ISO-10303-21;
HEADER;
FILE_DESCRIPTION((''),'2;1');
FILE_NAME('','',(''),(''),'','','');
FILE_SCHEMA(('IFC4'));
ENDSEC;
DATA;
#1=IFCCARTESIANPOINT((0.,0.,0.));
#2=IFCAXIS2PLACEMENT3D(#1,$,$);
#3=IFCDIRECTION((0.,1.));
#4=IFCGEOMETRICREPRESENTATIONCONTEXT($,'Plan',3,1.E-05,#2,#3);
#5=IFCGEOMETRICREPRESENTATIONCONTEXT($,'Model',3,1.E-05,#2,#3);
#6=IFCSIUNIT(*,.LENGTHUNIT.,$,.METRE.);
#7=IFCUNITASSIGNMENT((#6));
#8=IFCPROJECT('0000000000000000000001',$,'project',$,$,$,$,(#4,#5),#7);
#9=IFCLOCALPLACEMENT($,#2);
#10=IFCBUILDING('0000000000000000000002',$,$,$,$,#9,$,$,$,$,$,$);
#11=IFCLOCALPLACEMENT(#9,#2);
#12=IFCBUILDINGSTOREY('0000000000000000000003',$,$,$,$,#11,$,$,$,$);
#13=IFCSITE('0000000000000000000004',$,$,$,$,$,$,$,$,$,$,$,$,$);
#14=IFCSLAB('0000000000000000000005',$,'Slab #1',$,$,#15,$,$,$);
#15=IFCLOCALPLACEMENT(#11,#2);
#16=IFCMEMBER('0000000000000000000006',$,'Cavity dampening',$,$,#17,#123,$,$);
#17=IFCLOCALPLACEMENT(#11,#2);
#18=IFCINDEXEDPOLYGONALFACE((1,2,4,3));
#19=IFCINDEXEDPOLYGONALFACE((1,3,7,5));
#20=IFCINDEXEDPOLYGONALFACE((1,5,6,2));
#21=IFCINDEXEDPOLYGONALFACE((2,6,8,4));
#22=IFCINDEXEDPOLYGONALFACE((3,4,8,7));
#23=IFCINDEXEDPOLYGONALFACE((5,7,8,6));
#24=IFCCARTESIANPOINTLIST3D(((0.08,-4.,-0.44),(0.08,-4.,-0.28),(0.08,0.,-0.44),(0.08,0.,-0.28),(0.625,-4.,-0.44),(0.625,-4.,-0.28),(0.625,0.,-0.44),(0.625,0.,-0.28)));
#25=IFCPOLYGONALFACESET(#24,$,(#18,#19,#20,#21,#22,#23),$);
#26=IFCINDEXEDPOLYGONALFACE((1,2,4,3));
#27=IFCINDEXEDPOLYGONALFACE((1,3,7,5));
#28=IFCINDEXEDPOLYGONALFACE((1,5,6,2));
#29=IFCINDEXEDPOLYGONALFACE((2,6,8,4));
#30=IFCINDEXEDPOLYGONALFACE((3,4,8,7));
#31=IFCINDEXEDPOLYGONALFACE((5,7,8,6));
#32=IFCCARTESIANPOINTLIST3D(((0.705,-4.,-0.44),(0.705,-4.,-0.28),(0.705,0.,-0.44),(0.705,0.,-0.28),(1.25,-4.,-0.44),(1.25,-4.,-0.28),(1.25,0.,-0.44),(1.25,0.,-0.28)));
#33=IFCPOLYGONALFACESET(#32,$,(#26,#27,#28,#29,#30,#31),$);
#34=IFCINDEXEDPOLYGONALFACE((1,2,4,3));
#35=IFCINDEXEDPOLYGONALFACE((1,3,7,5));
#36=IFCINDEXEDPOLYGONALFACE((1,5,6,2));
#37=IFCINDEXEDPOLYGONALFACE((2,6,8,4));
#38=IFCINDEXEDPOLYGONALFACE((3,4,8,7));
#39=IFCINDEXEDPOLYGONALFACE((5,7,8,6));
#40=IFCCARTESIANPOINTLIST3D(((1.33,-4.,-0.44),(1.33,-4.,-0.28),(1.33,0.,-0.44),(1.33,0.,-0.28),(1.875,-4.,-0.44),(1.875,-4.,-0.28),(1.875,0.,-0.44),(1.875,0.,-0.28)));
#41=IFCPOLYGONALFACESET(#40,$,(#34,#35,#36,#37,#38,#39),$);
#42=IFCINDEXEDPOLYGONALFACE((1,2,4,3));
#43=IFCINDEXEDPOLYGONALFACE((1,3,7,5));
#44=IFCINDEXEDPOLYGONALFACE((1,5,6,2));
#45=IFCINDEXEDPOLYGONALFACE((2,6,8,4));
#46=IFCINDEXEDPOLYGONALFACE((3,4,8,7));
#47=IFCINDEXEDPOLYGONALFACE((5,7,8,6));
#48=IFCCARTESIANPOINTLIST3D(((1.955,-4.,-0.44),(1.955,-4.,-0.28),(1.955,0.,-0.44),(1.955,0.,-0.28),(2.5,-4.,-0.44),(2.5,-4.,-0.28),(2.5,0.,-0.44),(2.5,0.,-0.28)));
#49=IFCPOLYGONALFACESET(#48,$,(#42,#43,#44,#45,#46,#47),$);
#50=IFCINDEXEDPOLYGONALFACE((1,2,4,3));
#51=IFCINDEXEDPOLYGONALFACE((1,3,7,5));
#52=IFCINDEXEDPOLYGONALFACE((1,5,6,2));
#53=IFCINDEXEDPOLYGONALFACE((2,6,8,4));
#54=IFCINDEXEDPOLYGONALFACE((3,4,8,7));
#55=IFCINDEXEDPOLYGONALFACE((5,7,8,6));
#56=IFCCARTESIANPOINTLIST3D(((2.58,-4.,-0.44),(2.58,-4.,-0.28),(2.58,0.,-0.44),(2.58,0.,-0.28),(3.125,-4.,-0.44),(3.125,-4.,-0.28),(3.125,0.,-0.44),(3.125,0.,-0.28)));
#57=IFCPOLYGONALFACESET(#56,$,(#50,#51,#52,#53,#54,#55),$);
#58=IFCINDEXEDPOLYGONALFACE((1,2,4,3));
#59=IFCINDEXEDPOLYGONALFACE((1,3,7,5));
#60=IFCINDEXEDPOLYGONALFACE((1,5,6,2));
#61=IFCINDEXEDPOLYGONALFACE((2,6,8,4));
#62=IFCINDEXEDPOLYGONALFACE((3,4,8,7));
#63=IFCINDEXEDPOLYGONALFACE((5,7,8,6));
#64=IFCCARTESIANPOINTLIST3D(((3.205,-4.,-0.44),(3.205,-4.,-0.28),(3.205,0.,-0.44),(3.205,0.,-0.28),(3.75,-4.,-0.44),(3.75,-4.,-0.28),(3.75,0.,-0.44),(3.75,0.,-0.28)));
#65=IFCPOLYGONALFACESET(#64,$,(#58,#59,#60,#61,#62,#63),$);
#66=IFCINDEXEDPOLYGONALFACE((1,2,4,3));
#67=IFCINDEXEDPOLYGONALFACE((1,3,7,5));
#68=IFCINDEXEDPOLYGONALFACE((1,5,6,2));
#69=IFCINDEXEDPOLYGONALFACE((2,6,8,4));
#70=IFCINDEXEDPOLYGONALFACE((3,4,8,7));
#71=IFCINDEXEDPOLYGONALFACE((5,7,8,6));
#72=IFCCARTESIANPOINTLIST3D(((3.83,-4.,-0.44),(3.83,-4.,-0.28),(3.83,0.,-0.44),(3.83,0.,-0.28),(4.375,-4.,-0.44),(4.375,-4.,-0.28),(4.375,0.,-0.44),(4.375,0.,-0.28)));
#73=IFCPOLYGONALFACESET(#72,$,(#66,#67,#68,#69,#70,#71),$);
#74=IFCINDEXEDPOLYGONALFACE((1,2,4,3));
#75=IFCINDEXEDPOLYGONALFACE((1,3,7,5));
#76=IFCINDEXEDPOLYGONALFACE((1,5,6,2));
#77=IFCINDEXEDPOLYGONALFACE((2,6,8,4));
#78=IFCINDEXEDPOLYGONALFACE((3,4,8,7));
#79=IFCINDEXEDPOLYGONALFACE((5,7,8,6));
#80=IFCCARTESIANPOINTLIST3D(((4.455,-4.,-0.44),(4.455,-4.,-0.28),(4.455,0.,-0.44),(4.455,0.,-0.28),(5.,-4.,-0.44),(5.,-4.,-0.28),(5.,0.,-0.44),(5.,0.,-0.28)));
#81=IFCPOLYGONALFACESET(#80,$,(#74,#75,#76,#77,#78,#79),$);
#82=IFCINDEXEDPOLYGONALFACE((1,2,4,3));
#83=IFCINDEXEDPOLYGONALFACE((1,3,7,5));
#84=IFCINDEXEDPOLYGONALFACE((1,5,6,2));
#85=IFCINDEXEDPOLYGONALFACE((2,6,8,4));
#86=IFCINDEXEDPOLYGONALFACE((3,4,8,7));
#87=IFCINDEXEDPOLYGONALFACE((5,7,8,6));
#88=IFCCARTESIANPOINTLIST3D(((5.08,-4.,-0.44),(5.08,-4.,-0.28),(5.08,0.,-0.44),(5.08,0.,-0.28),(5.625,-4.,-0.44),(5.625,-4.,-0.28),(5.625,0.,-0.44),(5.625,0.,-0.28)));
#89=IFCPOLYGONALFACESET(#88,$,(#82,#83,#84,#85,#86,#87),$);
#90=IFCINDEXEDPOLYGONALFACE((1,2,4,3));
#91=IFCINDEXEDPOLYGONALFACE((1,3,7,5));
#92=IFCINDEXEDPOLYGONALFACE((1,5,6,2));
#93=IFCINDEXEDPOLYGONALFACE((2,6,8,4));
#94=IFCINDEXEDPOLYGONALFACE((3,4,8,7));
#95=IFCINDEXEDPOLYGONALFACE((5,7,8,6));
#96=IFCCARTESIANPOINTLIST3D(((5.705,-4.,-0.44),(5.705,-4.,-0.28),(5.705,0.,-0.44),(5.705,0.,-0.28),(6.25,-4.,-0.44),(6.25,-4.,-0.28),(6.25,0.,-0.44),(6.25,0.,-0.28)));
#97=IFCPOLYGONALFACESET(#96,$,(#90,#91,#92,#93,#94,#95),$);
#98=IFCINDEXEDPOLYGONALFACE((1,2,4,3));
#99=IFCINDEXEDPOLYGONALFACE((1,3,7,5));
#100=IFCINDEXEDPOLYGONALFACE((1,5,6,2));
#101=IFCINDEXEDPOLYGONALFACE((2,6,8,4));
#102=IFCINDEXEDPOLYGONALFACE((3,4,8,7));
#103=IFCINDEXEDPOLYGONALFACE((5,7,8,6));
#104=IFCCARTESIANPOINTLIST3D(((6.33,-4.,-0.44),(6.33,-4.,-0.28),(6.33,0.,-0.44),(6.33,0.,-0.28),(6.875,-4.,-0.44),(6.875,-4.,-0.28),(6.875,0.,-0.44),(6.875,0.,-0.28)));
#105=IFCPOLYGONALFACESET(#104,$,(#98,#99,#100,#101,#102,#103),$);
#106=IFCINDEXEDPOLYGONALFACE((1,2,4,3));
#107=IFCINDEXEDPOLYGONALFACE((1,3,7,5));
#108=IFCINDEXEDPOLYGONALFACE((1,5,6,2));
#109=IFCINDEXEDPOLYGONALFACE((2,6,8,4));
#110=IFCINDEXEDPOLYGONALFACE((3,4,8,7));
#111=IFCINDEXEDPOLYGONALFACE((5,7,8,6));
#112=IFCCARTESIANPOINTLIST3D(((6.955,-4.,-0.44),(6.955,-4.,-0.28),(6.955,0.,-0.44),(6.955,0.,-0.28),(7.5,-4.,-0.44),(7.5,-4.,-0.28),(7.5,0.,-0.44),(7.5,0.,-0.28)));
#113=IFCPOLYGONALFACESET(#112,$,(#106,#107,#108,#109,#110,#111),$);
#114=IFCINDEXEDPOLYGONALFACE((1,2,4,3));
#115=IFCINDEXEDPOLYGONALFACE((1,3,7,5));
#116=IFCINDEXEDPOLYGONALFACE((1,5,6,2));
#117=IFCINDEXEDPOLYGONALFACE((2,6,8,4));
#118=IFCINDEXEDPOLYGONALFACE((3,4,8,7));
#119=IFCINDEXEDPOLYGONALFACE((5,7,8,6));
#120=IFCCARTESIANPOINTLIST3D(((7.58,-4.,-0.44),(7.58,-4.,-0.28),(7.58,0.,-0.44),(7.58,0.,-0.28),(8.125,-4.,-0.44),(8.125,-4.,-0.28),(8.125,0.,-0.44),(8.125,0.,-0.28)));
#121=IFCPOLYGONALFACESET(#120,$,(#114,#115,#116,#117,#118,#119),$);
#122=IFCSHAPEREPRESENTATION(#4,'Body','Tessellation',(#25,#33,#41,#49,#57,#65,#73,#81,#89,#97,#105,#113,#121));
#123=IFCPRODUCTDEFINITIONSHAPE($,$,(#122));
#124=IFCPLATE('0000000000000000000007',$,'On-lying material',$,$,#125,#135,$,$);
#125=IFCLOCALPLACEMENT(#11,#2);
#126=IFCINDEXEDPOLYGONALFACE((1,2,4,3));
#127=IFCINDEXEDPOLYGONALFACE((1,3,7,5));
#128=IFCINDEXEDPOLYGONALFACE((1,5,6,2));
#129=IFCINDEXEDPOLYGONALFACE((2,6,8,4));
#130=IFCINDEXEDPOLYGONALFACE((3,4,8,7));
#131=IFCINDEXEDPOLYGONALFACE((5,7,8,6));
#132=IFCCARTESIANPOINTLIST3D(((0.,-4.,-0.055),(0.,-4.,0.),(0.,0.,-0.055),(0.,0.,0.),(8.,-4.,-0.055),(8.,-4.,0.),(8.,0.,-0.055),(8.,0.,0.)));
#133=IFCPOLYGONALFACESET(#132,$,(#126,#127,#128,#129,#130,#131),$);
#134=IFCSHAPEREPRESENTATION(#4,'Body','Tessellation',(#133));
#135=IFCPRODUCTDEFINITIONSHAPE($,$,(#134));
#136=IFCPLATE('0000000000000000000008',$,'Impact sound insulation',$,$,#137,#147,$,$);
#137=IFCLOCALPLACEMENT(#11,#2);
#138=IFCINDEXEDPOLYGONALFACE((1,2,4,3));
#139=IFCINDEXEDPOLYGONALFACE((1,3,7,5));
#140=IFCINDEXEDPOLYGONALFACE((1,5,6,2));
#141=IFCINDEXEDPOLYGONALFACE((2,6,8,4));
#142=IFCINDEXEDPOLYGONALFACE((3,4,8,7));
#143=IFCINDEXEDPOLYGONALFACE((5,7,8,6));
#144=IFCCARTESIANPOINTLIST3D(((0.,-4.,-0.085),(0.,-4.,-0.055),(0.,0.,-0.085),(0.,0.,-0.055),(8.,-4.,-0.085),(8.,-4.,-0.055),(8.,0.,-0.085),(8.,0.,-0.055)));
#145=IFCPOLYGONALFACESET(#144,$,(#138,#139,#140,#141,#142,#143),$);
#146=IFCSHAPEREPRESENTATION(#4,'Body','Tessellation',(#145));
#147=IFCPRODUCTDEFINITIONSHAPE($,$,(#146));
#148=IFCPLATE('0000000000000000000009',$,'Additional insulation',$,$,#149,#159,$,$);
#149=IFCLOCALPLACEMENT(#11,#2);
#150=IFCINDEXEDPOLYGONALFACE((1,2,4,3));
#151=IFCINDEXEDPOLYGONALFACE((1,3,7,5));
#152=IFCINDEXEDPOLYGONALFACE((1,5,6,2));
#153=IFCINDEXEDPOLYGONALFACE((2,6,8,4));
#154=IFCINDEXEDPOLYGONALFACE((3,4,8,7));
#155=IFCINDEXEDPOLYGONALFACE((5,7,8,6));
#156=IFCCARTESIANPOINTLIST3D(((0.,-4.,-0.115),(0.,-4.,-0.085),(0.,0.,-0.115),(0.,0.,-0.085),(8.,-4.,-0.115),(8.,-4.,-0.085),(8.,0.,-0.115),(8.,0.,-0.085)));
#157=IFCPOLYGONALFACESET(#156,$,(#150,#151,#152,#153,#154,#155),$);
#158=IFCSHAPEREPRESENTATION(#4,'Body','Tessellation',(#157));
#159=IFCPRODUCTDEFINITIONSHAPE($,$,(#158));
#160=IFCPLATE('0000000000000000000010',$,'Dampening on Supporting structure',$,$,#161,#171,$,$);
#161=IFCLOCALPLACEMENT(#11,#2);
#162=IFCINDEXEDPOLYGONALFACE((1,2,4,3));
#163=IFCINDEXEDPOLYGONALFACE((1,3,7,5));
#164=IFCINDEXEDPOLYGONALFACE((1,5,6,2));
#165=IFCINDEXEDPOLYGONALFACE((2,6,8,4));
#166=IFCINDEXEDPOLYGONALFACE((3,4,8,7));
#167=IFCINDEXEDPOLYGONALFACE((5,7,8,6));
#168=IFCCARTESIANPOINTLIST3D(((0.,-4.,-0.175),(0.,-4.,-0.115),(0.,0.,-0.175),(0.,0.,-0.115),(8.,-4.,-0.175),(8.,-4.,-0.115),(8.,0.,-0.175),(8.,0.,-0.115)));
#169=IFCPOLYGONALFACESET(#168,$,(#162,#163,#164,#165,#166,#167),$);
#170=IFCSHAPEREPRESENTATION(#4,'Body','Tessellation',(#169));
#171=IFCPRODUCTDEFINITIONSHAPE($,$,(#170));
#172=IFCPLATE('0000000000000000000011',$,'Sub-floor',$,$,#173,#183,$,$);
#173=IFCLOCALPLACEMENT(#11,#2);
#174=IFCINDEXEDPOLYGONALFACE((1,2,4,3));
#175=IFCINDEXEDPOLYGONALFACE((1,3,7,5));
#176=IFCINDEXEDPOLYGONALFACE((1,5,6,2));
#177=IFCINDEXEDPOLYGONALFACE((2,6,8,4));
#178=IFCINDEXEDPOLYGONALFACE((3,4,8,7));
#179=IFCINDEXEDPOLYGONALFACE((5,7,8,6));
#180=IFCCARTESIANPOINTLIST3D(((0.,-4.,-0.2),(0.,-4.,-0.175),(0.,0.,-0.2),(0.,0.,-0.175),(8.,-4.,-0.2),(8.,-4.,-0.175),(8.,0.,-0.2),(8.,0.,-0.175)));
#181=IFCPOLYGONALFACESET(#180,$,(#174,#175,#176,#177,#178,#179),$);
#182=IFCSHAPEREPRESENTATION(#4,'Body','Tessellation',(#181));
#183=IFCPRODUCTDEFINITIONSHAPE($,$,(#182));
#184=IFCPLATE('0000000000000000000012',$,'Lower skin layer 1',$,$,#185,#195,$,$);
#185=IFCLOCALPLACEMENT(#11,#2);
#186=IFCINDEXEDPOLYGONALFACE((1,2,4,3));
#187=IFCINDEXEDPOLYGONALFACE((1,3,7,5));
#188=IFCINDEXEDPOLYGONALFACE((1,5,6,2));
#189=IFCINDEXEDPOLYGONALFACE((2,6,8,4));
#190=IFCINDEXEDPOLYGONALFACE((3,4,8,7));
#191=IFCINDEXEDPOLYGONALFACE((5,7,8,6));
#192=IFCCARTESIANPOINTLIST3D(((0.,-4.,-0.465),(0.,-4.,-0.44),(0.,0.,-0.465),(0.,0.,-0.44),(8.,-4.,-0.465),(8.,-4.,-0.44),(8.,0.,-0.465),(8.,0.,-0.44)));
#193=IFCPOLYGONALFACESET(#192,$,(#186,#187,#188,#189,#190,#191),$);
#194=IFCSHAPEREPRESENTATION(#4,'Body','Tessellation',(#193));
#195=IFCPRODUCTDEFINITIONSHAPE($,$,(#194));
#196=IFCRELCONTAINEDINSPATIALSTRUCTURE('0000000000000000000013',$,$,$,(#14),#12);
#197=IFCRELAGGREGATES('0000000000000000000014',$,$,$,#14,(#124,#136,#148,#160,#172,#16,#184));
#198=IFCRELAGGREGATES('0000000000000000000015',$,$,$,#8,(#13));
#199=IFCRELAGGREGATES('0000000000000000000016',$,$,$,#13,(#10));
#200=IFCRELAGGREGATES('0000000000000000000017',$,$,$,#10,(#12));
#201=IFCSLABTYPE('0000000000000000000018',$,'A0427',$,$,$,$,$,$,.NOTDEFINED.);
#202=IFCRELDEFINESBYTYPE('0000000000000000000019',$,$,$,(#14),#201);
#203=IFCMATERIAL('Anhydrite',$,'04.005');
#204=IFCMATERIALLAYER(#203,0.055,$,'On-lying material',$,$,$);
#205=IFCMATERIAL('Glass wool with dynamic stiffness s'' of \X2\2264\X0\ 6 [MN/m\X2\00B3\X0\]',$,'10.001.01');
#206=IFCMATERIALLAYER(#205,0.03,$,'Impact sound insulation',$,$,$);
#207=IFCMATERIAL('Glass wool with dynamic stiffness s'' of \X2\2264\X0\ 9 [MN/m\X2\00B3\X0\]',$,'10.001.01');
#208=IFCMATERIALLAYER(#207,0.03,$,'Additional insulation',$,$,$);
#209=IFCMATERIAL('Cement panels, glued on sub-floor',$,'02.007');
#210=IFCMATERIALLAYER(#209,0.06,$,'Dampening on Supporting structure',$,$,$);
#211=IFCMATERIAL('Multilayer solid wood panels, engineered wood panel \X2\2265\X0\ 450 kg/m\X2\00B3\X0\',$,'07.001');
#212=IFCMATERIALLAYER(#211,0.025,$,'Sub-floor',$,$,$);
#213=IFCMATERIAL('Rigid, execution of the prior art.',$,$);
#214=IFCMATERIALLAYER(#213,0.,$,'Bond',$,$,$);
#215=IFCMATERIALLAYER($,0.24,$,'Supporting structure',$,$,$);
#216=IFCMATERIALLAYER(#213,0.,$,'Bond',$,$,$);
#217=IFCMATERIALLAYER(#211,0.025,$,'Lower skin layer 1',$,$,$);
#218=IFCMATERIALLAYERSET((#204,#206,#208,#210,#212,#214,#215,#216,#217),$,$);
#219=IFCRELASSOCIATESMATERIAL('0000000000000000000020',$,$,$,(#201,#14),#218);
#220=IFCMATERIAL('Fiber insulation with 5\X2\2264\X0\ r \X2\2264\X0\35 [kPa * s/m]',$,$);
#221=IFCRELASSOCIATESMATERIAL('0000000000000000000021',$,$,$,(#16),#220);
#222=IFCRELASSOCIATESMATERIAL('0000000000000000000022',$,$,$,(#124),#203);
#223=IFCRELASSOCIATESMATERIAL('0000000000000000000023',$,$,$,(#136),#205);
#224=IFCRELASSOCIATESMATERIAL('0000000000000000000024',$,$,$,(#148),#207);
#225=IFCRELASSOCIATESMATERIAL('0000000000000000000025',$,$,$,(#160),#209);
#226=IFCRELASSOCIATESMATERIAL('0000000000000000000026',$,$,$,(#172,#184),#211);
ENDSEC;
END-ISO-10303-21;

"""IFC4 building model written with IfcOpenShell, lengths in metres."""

from ifc_helpers import new_model, si_unit, direction, frame, frame_2d, origin, origin_with_axes, place, context, project, spatial, rectangle, extrude, material, layer, layer_set, type_object, element, aggregate, save


model = new_model("IFC4")

# Units and contexts
plan_context = context("Plan", 3, precision=1e-05, world=origin(), true_north=direction((0.0, 1.0)))
model_context = context("Model", 3, precision=1e-05, world=origin(), true_north=direction((0.0, 1.0)))
ifc_project = project(units=[si_unit("LENGTHUNIT", "METRE")], contexts=[plan_context, model_context])

# Site, building, storey
site = spatial("IfcSite", under=ifc_project)
building_placement = place(None, origin())
building = spatial("IfcBuilding", under=site, at=building_placement)
storey_placement = place(building_placement, origin())
storey = spatial("IfcBuildingStorey", under=building, at=storey_placement)

# Slab, member, plates
ifc_material_1 = material(Name="Anhydrite", Category="04.005")
ifc_layer_1 = layer(ifc_material_1, 0.055, Name="On-lying material")
ifc_material_2 = material(Name="Glass wool with dynamic stiffness s' of ≤ 6 [MN/m³]", Category="10.001.01")
ifc_layer_2 = layer(ifc_material_2, 0.03, Name="Impact sound insulation")
ifc_material_3 = material(Name="Glass wool with dynamic stiffness s' of ≤ 9 [MN/m³]", Category="10.001.01")
ifc_layer_3 = layer(ifc_material_3, 0.03, Name="Additional insulation")
ifc_material_4 = material(Name="Cement panels, glued on sub-floor", Category="02.007")
ifc_layer_4 = layer(ifc_material_4, 0.06, Name="Dampening on Supporting structure")
ifc_material_5 = material(Name="Multilayer solid wood panels, engineered wood panel ≥ 450 kg/m³", Category="07.001")
ifc_layer_5 = layer(ifc_material_5, 0.025, Name="Sub-floor")
ifc_material_6 = material(Name="Rigid, execution of the prior art.")
ifc_layer_6 = layer(ifc_material_6, 0.0, Name="Bond")
ifc_layer_7 = layer(None, 0.24, Name="Supporting structure")
ifc_layer_8 = layer(ifc_material_6, 0.0, Name="Bond")
ifc_layer_9 = layer(ifc_material_5, 0.025, Name="Lower skin layer 1")
ifc_layer_set = layer_set([ifc_layer_1, ifc_layer_2, ifc_layer_3, ifc_layer_4, ifc_layer_5, ifc_layer_6, ifc_layer_7, ifc_layer_8, ifc_layer_9])
slab_type = type_object("IfcSlabType", Name="A0427", PredefinedType="NOTDEFINED", material=ifc_layer_set)
slab_placement = place(None, frame((0.0, 0.0, 0.0), z_axis=(0.0, 0.0, -1.0), x_axis=(1.0, 0.0, 0.0)))
slab = element("IfcSlab", 1, at=slab_placement, inside=storey, type_object=slab_type, material=ifc_layer_set, Name="Slab #1")
ifc_material_7 = material(Name="Fiber insulation with 5≤ r ≤35 [kPa * s/m]")
member_1_placement = place(slab_placement, origin())
member_1 = element("IfcMember", 2, at=member_1_placement, material=ifc_material_7, Name="Cavity dampening", context=plan_context, shape_type="SweptSolid", body=[
    extrude(rectangle(XDim=0.545, YDim=0.16, at=frame_2d((0.2725, 0.08), x_axis=(1.0, 0.0))), frame((0.08, 4.0, 0.28), z_axis=(0.0, -1.0, 0.0), x_axis=(1.0, 0.0, 0.0)), (0.0, 0.0, 1.0), 4.0),
    extrude(rectangle(XDim=0.545, YDim=0.16, at=frame_2d((0.2725, 0.08), x_axis=(1.0, 0.0))), frame((0.705, 4.0, 0.28), z_axis=(0.0, -1.0, 0.0), x_axis=(1.0, 0.0, 0.0)), (0.0, 0.0, 1.0), 4.0),
    extrude(rectangle(XDim=0.545, YDim=0.16, at=frame_2d((0.2725, 0.08), x_axis=(1.0, 0.0))), frame((1.33, 4.0, 0.28), z_axis=(0.0, -1.0, 0.0), x_axis=(1.0, 0.0, 0.0)), (0.0, 0.0, 1.0), 4.0),
    extrude(rectangle(XDim=0.545, YDim=0.16, at=frame_2d((0.2725, 0.08), x_axis=(1.0, 0.0))), frame((1.955, 4.0, 0.28), z_axis=(0.0, -1.0, 0.0), x_axis=(1.0, 0.0, 0.0)), (0.0, 0.0, 1.0), 4.0),
    extrude(rectangle(XDim=0.545, YDim=0.16, at=frame_2d((0.2725, 0.08), x_axis=(1.0, 0.0))), frame((2.58, 4.0, 0.28), z_axis=(0.0, -1.0, 0.0), x_axis=(1.0, 0.0, 0.0)), (0.0, 0.0, 1.0), 4.0),
    extrude(rectangle(XDim=0.545, YDim=0.16, at=frame_2d((0.2725, 0.08), x_axis=(1.0, 0.0))), frame((3.205, 4.0, 0.28), z_axis=(0.0, -1.0, 0.0), x_axis=(1.0, 0.0, 0.0)), (0.0, 0.0, 1.0), 4.0),
    extrude(rectangle(XDim=0.545, YDim=0.16, at=frame_2d((0.2725, 0.08), x_axis=(1.0, 0.0))), frame((3.83, 4.0, 0.28), z_axis=(0.0, -1.0, 0.0), x_axis=(1.0, 0.0, 0.0)), (0.0, 0.0, 1.0), 4.0),
    extrude(rectangle(XDim=0.545, YDim=0.16, at=frame_2d((0.2725, 0.08), x_axis=(1.0, 0.0))), frame((4.455, 4.0, 0.28), z_axis=(0.0, -1.0, 0.0), x_axis=(1.0, 0.0, 0.0)), (0.0, 0.0, 1.0), 4.0),
    extrude(rectangle(XDim=0.545, YDim=0.16, at=frame_2d((0.2725, 0.08), x_axis=(1.0, 0.0))), frame((5.08, 4.0, 0.28), z_axis=(0.0, -1.0, 0.0), x_axis=(1.0, 0.0, 0.0)), (0.0, 0.0, 1.0), 4.0),
    extrude(rectangle(XDim=0.545, YDim=0.16, at=frame_2d((0.2725, 0.08), x_axis=(1.0, 0.0))), frame((5.705, 4.0, 0.28), z_axis=(0.0, -1.0, 0.0), x_axis=(1.0, 0.0, 0.0)), (0.0, 0.0, 1.0), 4.0),
    extrude(rectangle(XDim=0.545, YDim=0.16, at=frame_2d((0.2725, 0.08), x_axis=(1.0, 0.0))), frame((6.33, 4.0, 0.28), z_axis=(0.0, -1.0, 0.0), x_axis=(1.0, 0.0, 0.0)), (0.0, 0.0, 1.0), 4.0),
    extrude(rectangle(XDim=0.545, YDim=0.16, at=frame_2d((0.2725, 0.08), x_axis=(1.0, 0.0))), frame((6.955, 4.0, 0.28), z_axis=(0.0, -1.0, 0.0), x_axis=(1.0, 0.0, 0.0)), (0.0, 0.0, 1.0), 4.0),
    extrude(rectangle(XDim=0.545, YDim=0.16, at=frame_2d((0.2725, 0.08), x_axis=(1.0, 0.0))), frame((7.58, 4.0, 0.28), z_axis=(0.0, -1.0, 0.0), x_axis=(1.0, 0.0, 0.0)), (0.0, 0.0, 1.0), 4.0),
])
plate_1_placement = place(slab_placement, origin())
plate_1 = element("IfcPlate", 3, at=plate_1_placement, material=ifc_material_1, Name="On-lying material", context=plan_context, shape_type="SweptSolid", body=[
    extrude(rectangle(XDim=8.0, YDim=4.0, at=frame_2d((4.0, 2.0), x_axis=(1.0, 0.0))), origin_with_axes(), (0.0, 0.0, 1.0), 0.055),
])
plate_2_placement = place(slab_placement, origin())
plate_2 = element("IfcPlate", 4, at=plate_2_placement, material=ifc_material_2, Name="Impact sound insulation", context=plan_context, shape_type="SweptSolid", body=[
    extrude(rectangle(XDim=8.0, YDim=4.0, at=frame_2d((4.0, 2.0), x_axis=(1.0, 0.0))), frame((0.0, 0.0, 0.055), z_axis=(0.0, 0.0, 1.0), x_axis=(1.0, 0.0, 0.0)), (0.0, 0.0, 1.0), 0.03),
])
plate_3_placement = place(slab_placement, origin())
plate_3 = element("IfcPlate", 5, at=plate_3_placement, material=ifc_material_3, Name="Additional insulation", context=plan_context, shape_type="SweptSolid", body=[
    extrude(rectangle(XDim=8.0, YDim=4.0, at=frame_2d((4.0, 2.0), x_axis=(1.0, 0.0))), frame((0.0, 0.0, 0.085), z_axis=(0.0, 0.0, 1.0), x_axis=(1.0, 0.0, 0.0)), (0.0, 0.0, 1.0), 0.03),
])
plate_4_placement = place(slab_placement, origin())
plate_4 = element("IfcPlate", 6, at=plate_4_placement, material=ifc_material_4, Name="Dampening on Supporting structure", context=plan_context, shape_type="SweptSolid", body=[
    extrude(rectangle(XDim=8.0, YDim=4.0, at=frame_2d((4.0, 2.0), x_axis=(1.0, 0.0))), frame((0.0, 0.0, 0.115), z_axis=(0.0, 0.0, 1.0), x_axis=(1.0, 0.0, 0.0)), (0.0, 0.0, 1.0), 0.06),
])
plate_5_placement = place(slab_placement, origin())
plate_5 = element("IfcPlate", 7, at=plate_5_placement, material=ifc_material_5, Name="Sub-floor", context=plan_context, shape_type="SweptSolid", body=[
    extrude(rectangle(XDim=8.0, YDim=4.0, at=frame_2d((4.0, 2.0), x_axis=(1.0, 0.0))), frame((0.0, 0.0, 0.175), z_axis=(0.0, 0.0, 1.0), x_axis=(1.0, 0.0, 0.0)), (0.0, 0.0, 1.0), 0.025),
])
plate_6_placement = place(slab_placement, origin())
plate_6 = element("IfcPlate", 8, at=plate_6_placement, material=ifc_material_5, Name="Lower skin layer 1", context=plan_context, shape_type="SweptSolid", body=[
    extrude(rectangle(XDim=8.0, YDim=4.0, at=frame_2d((4.0, 2.0), x_axis=(1.0, 0.0))), frame((0.0, 0.0, 0.44), z_axis=(0.0, 0.0, 1.0), x_axis=(1.0, 0.0, 0.0)), (0.0, 0.0, 1.0), 0.025),
])
aggregate(slab, [plate_1, plate_2, plate_3, plate_4, plate_5, member_1, plate_6])

save(model, "model.ifc")
